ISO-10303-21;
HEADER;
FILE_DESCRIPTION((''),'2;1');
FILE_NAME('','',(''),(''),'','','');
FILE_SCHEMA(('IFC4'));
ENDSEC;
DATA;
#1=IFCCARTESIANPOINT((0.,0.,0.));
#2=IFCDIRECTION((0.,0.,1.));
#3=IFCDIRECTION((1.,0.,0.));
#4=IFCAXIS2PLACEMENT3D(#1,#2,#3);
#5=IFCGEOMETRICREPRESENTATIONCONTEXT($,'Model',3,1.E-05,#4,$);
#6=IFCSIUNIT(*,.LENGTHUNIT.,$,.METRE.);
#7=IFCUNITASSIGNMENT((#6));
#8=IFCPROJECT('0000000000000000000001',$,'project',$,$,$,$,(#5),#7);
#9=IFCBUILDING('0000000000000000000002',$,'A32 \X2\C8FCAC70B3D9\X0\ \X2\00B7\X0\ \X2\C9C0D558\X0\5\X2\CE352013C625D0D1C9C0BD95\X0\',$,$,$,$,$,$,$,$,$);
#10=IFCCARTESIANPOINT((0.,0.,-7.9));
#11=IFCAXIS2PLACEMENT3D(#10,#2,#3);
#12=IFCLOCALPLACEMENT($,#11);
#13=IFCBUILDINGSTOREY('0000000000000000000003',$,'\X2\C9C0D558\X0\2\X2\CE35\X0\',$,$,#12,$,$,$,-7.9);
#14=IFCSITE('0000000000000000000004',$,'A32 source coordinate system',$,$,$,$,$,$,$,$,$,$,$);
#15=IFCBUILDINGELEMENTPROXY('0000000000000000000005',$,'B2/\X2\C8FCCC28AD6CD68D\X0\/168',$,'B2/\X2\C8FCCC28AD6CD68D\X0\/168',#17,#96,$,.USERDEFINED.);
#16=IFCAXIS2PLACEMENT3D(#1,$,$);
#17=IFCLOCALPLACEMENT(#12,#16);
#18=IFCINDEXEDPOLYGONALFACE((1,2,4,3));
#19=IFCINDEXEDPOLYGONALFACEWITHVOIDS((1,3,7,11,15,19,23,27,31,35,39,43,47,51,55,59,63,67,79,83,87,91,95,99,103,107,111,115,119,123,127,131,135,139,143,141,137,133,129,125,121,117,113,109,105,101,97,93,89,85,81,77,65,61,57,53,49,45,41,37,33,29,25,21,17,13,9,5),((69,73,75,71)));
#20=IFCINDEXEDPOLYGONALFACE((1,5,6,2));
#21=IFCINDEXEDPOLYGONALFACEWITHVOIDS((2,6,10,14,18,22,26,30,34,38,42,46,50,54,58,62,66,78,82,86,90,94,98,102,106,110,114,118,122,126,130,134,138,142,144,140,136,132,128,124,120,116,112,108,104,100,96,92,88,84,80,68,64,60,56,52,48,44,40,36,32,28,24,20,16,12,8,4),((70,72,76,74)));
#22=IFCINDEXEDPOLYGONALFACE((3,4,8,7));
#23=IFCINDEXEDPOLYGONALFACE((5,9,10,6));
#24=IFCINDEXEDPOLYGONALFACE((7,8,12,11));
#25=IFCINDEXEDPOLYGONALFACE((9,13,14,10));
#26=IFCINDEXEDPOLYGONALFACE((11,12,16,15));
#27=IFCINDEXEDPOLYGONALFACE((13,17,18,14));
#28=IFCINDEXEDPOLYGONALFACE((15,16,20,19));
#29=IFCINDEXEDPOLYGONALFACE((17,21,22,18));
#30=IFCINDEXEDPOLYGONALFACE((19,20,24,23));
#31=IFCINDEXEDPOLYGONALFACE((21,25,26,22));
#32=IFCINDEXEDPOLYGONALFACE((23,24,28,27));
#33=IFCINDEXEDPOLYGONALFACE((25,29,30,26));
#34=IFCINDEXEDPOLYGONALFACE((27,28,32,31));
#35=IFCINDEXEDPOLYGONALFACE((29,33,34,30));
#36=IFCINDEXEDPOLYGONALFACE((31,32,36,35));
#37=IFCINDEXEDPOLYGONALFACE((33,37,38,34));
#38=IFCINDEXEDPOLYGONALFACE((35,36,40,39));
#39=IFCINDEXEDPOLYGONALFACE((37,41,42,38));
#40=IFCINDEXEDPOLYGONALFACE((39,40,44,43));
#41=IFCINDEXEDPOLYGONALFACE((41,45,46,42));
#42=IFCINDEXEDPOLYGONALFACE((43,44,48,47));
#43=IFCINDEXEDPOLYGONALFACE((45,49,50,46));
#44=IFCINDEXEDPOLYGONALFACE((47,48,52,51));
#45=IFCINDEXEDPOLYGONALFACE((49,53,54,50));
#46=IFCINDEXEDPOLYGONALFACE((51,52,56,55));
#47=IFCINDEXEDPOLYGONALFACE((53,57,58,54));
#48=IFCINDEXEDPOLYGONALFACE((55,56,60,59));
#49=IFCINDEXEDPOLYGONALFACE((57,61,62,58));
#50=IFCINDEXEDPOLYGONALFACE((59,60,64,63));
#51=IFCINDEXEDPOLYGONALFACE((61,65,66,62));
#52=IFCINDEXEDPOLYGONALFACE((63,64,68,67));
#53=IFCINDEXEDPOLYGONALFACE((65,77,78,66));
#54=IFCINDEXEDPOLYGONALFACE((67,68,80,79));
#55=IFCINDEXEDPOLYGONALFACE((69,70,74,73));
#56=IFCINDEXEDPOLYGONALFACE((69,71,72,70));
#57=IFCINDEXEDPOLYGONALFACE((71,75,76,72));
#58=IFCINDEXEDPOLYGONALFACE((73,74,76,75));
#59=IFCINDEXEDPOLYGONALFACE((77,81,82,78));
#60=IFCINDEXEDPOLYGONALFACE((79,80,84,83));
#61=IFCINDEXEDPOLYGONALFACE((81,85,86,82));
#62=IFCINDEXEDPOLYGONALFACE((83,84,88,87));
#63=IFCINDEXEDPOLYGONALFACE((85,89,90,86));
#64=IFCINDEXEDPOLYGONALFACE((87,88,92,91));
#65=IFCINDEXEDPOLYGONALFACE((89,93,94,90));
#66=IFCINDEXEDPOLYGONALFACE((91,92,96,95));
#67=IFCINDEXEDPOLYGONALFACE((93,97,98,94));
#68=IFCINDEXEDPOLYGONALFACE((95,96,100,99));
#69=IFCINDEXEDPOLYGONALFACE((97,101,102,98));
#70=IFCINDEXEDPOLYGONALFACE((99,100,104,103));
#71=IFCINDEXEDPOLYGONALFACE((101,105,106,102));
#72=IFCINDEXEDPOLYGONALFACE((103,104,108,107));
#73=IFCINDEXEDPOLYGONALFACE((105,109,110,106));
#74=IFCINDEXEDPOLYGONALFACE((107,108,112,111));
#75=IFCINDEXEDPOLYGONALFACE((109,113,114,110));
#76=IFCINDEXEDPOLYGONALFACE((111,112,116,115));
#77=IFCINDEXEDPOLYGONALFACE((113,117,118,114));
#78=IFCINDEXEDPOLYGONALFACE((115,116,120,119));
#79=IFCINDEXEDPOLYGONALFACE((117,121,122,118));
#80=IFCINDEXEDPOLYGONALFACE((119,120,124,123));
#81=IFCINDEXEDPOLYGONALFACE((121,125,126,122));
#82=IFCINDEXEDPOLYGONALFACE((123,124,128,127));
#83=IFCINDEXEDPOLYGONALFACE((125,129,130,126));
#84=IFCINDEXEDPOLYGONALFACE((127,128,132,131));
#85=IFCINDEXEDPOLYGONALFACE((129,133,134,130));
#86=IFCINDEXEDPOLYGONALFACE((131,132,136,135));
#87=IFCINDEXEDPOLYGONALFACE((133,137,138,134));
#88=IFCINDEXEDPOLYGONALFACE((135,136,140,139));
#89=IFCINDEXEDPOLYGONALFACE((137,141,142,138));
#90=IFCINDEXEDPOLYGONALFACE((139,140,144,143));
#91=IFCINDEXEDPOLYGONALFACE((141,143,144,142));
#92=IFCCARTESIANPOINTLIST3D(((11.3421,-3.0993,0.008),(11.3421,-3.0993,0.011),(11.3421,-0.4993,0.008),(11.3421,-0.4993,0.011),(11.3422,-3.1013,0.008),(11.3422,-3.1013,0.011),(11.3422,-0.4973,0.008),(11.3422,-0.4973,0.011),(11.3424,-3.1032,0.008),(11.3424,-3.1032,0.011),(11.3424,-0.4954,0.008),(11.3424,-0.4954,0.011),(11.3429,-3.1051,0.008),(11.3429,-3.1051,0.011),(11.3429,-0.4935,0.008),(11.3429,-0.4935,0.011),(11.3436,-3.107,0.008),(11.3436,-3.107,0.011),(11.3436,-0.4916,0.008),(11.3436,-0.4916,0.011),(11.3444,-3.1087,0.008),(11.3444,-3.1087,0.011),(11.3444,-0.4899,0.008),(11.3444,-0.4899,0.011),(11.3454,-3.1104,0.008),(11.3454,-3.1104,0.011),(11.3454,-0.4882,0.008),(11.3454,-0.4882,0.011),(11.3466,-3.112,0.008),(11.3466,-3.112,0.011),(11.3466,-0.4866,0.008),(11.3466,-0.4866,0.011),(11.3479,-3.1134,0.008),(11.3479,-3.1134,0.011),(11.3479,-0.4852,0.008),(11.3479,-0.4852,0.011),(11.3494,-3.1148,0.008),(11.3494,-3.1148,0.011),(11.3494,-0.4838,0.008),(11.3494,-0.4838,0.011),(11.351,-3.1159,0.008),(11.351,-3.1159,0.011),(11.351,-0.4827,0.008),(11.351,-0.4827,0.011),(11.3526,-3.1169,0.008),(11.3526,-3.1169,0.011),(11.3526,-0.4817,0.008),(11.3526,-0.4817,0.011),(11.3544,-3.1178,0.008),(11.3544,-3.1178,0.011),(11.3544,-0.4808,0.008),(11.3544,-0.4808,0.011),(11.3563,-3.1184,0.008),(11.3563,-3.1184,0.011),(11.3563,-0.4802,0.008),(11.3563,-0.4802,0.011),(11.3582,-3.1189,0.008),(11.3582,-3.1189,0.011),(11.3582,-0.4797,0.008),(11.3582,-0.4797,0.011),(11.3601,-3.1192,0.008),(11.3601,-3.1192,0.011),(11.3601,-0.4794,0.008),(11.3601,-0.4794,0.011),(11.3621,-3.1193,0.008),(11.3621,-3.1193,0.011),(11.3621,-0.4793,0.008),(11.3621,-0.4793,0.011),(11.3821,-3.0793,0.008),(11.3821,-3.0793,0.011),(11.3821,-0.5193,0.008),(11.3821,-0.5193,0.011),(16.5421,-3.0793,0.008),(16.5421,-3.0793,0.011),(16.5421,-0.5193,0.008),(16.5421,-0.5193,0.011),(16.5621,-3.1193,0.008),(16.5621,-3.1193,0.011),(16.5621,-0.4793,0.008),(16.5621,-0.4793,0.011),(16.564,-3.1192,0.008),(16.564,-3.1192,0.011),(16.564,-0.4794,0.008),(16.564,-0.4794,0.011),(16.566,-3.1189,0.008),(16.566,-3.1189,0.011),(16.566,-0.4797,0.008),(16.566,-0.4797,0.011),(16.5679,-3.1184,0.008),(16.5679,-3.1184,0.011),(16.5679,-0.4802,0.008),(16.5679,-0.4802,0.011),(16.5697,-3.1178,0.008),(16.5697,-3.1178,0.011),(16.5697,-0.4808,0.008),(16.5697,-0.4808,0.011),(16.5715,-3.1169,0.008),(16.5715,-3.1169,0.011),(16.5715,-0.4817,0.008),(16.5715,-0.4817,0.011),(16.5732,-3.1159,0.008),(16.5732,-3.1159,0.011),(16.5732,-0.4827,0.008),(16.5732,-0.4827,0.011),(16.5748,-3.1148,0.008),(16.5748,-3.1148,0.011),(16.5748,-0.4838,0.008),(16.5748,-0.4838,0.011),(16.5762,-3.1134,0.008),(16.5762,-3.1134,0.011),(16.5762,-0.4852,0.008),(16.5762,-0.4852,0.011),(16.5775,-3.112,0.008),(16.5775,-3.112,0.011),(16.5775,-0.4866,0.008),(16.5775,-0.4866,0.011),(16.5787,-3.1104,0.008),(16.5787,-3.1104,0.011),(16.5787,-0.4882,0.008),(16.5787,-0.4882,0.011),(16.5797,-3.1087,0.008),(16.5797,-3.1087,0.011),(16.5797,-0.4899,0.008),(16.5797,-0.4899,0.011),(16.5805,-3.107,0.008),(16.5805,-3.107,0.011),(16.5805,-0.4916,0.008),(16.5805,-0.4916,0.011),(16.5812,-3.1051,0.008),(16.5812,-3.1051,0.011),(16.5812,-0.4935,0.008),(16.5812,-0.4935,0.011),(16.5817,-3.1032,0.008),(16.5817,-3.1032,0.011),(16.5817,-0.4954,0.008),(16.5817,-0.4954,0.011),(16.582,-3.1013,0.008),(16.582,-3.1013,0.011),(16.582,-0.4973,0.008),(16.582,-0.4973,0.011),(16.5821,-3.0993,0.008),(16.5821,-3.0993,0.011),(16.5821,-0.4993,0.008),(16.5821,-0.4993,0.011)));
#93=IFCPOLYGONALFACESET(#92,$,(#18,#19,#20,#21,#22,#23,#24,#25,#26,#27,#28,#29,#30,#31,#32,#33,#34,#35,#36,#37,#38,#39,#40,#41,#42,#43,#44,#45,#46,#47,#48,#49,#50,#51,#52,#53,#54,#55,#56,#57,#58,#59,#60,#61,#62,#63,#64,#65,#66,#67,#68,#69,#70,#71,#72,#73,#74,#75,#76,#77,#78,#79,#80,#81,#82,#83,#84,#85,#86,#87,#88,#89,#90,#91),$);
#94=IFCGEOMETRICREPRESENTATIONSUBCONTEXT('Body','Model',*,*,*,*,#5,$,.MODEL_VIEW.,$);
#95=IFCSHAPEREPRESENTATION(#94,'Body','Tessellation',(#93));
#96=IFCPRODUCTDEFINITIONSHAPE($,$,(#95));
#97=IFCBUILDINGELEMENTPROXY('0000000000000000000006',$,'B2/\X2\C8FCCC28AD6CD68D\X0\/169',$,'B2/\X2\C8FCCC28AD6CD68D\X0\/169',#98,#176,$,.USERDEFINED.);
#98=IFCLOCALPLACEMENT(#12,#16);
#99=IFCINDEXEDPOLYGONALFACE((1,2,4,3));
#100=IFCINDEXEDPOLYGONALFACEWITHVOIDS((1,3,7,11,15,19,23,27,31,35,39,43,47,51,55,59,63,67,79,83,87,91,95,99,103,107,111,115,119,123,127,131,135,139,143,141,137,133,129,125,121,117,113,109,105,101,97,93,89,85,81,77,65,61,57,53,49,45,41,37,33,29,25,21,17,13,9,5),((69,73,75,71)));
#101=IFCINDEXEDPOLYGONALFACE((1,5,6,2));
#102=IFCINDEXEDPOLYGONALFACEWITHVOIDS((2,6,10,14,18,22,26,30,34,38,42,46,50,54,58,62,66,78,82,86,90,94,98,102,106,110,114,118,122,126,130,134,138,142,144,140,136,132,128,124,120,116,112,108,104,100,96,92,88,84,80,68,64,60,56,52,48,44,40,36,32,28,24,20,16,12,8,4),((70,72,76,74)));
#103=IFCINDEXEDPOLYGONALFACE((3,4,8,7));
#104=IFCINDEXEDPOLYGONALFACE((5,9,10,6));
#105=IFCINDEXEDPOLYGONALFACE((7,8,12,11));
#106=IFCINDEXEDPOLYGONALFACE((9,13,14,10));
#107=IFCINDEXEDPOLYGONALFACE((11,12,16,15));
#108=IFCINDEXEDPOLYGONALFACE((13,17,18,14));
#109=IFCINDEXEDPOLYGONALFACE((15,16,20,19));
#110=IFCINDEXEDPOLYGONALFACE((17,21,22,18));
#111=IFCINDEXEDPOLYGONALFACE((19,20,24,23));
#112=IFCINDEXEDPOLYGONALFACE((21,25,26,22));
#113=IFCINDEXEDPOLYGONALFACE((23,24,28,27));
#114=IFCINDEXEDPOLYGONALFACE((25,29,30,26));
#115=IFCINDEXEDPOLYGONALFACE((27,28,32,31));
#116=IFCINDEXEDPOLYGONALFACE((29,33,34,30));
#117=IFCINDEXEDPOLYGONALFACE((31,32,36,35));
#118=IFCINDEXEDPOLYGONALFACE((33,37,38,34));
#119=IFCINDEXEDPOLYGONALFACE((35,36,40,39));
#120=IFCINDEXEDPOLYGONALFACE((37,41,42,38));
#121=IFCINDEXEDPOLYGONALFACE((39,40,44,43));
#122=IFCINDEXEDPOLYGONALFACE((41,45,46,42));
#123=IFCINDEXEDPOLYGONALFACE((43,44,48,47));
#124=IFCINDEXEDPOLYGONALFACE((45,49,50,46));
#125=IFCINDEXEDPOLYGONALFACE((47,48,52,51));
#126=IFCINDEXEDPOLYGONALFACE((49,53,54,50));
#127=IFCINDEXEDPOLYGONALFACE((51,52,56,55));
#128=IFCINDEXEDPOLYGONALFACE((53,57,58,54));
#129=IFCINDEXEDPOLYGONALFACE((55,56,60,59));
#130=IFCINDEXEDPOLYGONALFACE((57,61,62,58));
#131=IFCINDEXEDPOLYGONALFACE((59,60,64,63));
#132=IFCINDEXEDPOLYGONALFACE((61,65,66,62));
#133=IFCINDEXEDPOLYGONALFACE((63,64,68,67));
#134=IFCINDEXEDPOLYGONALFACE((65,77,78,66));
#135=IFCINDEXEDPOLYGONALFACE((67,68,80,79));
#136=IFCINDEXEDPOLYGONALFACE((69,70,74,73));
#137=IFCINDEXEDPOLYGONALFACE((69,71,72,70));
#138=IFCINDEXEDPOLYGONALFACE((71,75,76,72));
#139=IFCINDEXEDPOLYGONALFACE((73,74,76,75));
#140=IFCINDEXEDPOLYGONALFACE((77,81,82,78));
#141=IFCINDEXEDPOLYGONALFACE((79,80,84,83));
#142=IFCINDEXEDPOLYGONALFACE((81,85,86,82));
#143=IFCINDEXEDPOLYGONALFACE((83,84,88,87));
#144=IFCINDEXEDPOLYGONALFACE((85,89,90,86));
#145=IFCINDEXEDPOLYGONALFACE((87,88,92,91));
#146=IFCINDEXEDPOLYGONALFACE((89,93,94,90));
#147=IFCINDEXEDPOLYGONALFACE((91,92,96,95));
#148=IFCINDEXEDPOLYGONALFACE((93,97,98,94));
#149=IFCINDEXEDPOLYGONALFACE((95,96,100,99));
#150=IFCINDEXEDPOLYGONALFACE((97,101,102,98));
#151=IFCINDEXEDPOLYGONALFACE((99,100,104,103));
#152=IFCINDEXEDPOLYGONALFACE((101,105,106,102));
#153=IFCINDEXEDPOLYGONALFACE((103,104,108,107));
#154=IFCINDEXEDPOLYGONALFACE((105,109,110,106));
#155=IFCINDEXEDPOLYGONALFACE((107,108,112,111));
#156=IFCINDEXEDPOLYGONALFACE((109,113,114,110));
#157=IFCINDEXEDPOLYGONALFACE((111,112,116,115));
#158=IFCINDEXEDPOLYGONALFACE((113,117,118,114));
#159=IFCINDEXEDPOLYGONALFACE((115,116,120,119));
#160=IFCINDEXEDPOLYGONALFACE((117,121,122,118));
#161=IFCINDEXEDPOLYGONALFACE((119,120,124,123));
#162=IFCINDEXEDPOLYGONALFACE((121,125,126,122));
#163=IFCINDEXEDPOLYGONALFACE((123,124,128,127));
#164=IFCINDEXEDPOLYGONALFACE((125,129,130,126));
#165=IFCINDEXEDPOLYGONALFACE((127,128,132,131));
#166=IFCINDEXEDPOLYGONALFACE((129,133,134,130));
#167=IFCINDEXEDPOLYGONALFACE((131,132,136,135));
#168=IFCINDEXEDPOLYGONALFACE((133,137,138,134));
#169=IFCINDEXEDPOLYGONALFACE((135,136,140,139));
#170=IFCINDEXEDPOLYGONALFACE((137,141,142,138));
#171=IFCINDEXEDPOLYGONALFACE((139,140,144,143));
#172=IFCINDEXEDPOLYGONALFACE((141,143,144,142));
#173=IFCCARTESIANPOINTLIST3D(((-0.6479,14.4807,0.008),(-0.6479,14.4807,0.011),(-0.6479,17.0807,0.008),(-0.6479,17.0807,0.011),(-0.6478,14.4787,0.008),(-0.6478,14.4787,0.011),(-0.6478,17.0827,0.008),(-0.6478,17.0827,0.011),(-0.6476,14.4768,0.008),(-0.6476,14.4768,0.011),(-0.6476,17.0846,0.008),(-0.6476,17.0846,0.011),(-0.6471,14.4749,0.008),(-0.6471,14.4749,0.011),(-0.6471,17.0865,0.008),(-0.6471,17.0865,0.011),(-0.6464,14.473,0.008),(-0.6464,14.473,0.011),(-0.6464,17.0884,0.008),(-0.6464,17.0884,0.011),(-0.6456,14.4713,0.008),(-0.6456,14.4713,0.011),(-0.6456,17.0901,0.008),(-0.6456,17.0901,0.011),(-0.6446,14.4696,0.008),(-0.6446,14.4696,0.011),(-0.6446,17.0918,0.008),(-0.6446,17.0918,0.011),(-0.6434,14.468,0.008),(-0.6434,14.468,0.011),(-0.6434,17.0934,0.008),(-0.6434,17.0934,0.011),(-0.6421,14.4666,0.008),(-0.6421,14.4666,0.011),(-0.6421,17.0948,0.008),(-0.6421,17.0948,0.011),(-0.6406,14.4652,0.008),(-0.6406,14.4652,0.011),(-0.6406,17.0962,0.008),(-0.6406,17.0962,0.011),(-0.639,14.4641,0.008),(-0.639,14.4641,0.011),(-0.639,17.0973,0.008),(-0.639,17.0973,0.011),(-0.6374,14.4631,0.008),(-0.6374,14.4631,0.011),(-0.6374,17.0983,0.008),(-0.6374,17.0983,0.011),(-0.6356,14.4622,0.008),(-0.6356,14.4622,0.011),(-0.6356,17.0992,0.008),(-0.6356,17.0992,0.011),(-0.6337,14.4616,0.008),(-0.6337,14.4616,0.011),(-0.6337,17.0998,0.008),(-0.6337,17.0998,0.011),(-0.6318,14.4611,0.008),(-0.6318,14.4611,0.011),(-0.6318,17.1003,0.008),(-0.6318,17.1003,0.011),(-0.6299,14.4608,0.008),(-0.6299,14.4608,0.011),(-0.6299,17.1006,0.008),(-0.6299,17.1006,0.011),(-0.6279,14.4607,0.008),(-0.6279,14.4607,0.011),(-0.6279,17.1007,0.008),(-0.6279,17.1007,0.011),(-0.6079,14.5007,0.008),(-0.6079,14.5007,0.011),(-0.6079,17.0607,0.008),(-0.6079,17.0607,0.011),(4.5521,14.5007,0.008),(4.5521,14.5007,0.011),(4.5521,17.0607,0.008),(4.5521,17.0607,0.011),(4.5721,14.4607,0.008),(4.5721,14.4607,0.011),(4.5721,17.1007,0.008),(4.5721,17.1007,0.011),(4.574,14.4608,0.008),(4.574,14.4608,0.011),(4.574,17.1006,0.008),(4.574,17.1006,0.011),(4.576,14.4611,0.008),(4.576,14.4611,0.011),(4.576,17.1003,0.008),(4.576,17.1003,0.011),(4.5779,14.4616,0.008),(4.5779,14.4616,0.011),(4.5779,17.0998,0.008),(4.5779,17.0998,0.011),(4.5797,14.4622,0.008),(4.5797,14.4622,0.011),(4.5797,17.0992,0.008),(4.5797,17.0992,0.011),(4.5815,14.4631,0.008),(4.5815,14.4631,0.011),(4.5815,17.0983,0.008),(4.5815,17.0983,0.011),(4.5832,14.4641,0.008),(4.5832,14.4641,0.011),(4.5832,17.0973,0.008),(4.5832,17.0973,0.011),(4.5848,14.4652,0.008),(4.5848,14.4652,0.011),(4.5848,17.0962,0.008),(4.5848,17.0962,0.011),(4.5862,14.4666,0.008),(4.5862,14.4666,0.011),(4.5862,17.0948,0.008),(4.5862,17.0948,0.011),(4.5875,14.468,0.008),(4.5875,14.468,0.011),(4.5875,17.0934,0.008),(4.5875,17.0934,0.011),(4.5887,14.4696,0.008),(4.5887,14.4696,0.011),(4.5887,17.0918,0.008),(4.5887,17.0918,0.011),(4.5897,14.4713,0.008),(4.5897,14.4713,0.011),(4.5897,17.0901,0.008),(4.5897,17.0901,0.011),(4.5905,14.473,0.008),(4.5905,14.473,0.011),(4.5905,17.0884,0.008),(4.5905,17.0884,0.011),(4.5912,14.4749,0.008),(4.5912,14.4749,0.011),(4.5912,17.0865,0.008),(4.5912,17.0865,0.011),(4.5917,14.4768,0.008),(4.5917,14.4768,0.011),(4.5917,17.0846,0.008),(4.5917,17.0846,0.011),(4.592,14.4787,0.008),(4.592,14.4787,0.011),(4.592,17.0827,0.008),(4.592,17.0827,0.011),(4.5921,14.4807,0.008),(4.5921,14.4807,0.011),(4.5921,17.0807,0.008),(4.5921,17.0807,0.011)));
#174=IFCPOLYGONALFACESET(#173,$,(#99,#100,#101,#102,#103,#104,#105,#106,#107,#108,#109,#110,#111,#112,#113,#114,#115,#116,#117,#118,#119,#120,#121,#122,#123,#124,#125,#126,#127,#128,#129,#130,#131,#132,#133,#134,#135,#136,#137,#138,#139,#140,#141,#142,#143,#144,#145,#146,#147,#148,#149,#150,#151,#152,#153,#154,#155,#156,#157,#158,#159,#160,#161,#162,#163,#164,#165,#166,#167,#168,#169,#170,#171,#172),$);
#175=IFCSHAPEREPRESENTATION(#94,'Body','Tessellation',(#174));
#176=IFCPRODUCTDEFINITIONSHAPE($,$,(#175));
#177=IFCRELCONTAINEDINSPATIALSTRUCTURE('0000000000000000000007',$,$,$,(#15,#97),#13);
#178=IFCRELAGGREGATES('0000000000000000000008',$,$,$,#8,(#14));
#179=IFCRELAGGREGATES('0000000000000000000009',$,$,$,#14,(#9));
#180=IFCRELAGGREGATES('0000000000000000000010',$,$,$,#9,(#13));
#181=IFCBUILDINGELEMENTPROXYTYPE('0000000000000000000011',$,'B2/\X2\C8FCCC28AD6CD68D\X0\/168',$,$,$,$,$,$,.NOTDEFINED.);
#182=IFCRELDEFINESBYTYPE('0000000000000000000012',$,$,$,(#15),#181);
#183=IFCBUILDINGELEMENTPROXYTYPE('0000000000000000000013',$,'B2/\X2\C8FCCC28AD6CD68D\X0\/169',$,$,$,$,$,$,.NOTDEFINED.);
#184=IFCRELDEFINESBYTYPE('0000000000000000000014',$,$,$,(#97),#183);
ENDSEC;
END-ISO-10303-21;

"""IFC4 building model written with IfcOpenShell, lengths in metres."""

from ifc_helpers import new_model, si_unit, frame, origin, origin_with_axes, place, context, subcontext, project, spatial, polyline, outline, extrude, source, transform, mapped, type_object, type_shapes, element, save


model = new_model("IFC4")

# Units and contexts
model_context = context("Model", 3, precision=1e-05, world=origin_with_axes())
body_context = subcontext(model_context, "Body", "Model", "MODEL_VIEW")
ifc_project = project(units=[si_unit("LENGTHUNIT", "METRE")], contexts=[model_context])

# Site, building, storey
site = spatial("IfcSite", under=ifc_project, Name="A32 source coordinate system")
building = spatial("IfcBuilding", under=site, Name="A32 주거동 · 지하5층–옥탑지붕")
storey_placement = place(None, frame((0.0, 0.0, -7.9), z_axis=(0.0, 0.0, 1.0), x_axis=(1.0, 0.0, 0.0)))
storey = spatial("IfcBuildingStorey", under=building, at=storey_placement, Name="지하2층", Elevation=-7.9)

# Building element proxies
building_element_proxy_type_1 = type_object("IfcBuildingElementProxyType", Name="B2/주차구획/168", PredefinedType="NOTDEFINED")
shared_shape_1 = source(origin(), body_context, "Body", "SweptSolid", [
    extrude(outline(polyline([(11.3421, -0.4993), (11.3422, -0.4973), (11.3424, -0.4954), (11.3429, -0.4935), (11.3436, -0.4916), (11.3444, -0.4899), (11.3454, -0.4882), (11.3466, -0.4866), (11.3479, -0.4852), (11.3494, -0.4838), (11.351, -0.4827), (11.3526, -0.4817), (11.3544, -0.4808), (11.3563, -0.4802), (11.3582, -0.4797), (11.3601, -0.4794), (11.3621, -0.4793), (16.5621, -0.4793), (16.564, -0.4794), (16.566, -0.4797), (16.5679, -0.4802), (16.5697, -0.4808), (16.5715, -0.4817), (16.5732, -0.4827), (16.5748, -0.4838), (16.5762, -0.4852), (16.5775, -0.4866), (16.5787, -0.4882), (16.5797, -0.4899), (16.5805, -0.4916), (16.5812, -0.4935), (16.5817, -0.4954), (16.582, -0.4973), (16.5821, -0.4993), (16.5821, -3.0993), (16.582, -3.1013), (16.5817, -3.1032), (16.5812, -3.1051), (16.5805, -3.107), (16.5797, -3.1087), (16.5787, -3.1104), (16.5775, -3.112), (16.5762, -3.1134), (16.5748, -3.1148), (16.5732, -3.1159), (16.5715, -3.1169), (16.5697, -3.1178), (16.5679, -3.1184), (16.566, -3.1189), (16.564, -3.1192), (16.5621, -3.1193), (11.3621, -3.1193), (11.3601, -3.1192), (11.3582, -3.1189), (11.3563, -3.1184), (11.3544, -3.1178), (11.3526, -3.1169), (11.351, -3.1159), (11.3494, -3.1148), (11.3479, -3.1134), (11.3466, -3.112), (11.3454, -3.1104), (11.3444, -3.1087), (11.3436, -3.107), (11.3429, -3.1051), (11.3424, -3.1032), (11.3422, -3.1013), (11.3421, -3.0993), (11.3421, -0.4993)]), holes=[polyline([(11.3821, -0.5193), (11.3821, -3.0793), (16.5421, -3.0793), (16.5421, -0.5193), (11.3821, -0.5193)])]), frame((0.0, 0.0, 0.008)), (0.0, 0.0, 1.0), 0.003),
])
type_shapes(building_element_proxy_type_1, [shared_shape_1])
proxy_1_placement = place(storey_placement, origin_with_axes())
element("IfcBuildingElementProxy", 1, at=proxy_1_placement, inside=storey, type_object=building_element_proxy_type_1, Name="B2/주차구획/168", ObjectType="B2/주차구획/168", PredefinedType="USERDEFINED", context=body_context, shape_type="MappedRepresentation", body=[
    mapped(shared_shape_1, transform((0.0, 0.0, 0.0), scale=1.0)),
])
building_element_proxy_type_2 = type_object("IfcBuildingElementProxyType", Name="B2/주차구획/169", PredefinedType="NOTDEFINED")
shared_shape_2 = source(origin(), body_context, "Body", "SweptSolid", [
    extrude(outline(polyline([(4.5921, 14.4807), (4.592, 14.4787), (4.5917, 14.4768), (4.5912, 14.4749), (4.5905, 14.473), (4.5897, 14.4713), (4.5887, 14.4696), (4.5875, 14.468), (4.5862, 14.4666), (4.5848, 14.4652), (4.5832, 14.4641), (4.5815, 14.4631), (4.5797, 14.4622), (4.5779, 14.4616), (4.576, 14.4611), (4.574, 14.4608), (4.5721, 14.4607), (-0.6279, 14.4607), (-0.6299, 14.4608), (-0.6318, 14.4611), (-0.6337, 14.4616), (-0.6356, 14.4622), (-0.6374, 14.4631), (-0.639, 14.4641), (-0.6406, 14.4652), (-0.6421, 14.4666), (-0.6434, 14.468), (-0.6446, 14.4696), (-0.6456, 14.4713), (-0.6464, 14.473), (-0.6471, 14.4749), (-0.6476, 14.4768), (-0.6478, 14.4787), (-0.6479, 14.4807), (-0.6479, 17.0807), (-0.6478, 17.0827), (-0.6476, 17.0846), (-0.6471, 17.0865), (-0.6464, 17.0884), (-0.6456, 17.0901), (-0.6446, 17.0918), (-0.6434, 17.0934), (-0.6421, 17.0948), (-0.6406, 17.0962), (-0.639, 17.0973), (-0.6374, 17.0983), (-0.6356, 17.0992), (-0.6337, 17.0998), (-0.6318, 17.1003), (-0.6299, 17.1006), (-0.6279, 17.1007), (4.5721, 17.1007), (4.574, 17.1006), (4.576, 17.1003), (4.5779, 17.0998), (4.5797, 17.0992), (4.5815, 17.0983), (4.5832, 17.0973), (4.5848, 17.0962), (4.5862, 17.0948), (4.5875, 17.0934), (4.5887, 17.0918), (4.5897, 17.0901), (4.5905, 17.0884), (4.5912, 17.0865), (4.5917, 17.0846), (4.592, 17.0827), (4.5921, 17.0807), (4.5921, 14.4807)]), holes=[polyline([(4.5521, 14.5007), (4.5521, 17.0607), (-0.6079, 17.0607), (-0.6079, 14.5007), (4.5521, 14.5007)])]), frame((0.0, 0.0, 0.008)), (0.0, 0.0, 1.0), 0.003),
])
type_shapes(building_element_proxy_type_2, [shared_shape_2])
proxy_2_placement = place(storey_placement, origin_with_axes())
element("IfcBuildingElementProxy", 2, at=proxy_2_placement, inside=storey, type_object=building_element_proxy_type_2, Name="B2/주차구획/169", ObjectType="B2/주차구획/169", PredefinedType="USERDEFINED", context=body_context, shape_type="MappedRepresentation", body=[
    mapped(shared_shape_2, transform((0.0, 0.0, 0.0), scale=1.0)),
])

save(model, "model.ifc")
